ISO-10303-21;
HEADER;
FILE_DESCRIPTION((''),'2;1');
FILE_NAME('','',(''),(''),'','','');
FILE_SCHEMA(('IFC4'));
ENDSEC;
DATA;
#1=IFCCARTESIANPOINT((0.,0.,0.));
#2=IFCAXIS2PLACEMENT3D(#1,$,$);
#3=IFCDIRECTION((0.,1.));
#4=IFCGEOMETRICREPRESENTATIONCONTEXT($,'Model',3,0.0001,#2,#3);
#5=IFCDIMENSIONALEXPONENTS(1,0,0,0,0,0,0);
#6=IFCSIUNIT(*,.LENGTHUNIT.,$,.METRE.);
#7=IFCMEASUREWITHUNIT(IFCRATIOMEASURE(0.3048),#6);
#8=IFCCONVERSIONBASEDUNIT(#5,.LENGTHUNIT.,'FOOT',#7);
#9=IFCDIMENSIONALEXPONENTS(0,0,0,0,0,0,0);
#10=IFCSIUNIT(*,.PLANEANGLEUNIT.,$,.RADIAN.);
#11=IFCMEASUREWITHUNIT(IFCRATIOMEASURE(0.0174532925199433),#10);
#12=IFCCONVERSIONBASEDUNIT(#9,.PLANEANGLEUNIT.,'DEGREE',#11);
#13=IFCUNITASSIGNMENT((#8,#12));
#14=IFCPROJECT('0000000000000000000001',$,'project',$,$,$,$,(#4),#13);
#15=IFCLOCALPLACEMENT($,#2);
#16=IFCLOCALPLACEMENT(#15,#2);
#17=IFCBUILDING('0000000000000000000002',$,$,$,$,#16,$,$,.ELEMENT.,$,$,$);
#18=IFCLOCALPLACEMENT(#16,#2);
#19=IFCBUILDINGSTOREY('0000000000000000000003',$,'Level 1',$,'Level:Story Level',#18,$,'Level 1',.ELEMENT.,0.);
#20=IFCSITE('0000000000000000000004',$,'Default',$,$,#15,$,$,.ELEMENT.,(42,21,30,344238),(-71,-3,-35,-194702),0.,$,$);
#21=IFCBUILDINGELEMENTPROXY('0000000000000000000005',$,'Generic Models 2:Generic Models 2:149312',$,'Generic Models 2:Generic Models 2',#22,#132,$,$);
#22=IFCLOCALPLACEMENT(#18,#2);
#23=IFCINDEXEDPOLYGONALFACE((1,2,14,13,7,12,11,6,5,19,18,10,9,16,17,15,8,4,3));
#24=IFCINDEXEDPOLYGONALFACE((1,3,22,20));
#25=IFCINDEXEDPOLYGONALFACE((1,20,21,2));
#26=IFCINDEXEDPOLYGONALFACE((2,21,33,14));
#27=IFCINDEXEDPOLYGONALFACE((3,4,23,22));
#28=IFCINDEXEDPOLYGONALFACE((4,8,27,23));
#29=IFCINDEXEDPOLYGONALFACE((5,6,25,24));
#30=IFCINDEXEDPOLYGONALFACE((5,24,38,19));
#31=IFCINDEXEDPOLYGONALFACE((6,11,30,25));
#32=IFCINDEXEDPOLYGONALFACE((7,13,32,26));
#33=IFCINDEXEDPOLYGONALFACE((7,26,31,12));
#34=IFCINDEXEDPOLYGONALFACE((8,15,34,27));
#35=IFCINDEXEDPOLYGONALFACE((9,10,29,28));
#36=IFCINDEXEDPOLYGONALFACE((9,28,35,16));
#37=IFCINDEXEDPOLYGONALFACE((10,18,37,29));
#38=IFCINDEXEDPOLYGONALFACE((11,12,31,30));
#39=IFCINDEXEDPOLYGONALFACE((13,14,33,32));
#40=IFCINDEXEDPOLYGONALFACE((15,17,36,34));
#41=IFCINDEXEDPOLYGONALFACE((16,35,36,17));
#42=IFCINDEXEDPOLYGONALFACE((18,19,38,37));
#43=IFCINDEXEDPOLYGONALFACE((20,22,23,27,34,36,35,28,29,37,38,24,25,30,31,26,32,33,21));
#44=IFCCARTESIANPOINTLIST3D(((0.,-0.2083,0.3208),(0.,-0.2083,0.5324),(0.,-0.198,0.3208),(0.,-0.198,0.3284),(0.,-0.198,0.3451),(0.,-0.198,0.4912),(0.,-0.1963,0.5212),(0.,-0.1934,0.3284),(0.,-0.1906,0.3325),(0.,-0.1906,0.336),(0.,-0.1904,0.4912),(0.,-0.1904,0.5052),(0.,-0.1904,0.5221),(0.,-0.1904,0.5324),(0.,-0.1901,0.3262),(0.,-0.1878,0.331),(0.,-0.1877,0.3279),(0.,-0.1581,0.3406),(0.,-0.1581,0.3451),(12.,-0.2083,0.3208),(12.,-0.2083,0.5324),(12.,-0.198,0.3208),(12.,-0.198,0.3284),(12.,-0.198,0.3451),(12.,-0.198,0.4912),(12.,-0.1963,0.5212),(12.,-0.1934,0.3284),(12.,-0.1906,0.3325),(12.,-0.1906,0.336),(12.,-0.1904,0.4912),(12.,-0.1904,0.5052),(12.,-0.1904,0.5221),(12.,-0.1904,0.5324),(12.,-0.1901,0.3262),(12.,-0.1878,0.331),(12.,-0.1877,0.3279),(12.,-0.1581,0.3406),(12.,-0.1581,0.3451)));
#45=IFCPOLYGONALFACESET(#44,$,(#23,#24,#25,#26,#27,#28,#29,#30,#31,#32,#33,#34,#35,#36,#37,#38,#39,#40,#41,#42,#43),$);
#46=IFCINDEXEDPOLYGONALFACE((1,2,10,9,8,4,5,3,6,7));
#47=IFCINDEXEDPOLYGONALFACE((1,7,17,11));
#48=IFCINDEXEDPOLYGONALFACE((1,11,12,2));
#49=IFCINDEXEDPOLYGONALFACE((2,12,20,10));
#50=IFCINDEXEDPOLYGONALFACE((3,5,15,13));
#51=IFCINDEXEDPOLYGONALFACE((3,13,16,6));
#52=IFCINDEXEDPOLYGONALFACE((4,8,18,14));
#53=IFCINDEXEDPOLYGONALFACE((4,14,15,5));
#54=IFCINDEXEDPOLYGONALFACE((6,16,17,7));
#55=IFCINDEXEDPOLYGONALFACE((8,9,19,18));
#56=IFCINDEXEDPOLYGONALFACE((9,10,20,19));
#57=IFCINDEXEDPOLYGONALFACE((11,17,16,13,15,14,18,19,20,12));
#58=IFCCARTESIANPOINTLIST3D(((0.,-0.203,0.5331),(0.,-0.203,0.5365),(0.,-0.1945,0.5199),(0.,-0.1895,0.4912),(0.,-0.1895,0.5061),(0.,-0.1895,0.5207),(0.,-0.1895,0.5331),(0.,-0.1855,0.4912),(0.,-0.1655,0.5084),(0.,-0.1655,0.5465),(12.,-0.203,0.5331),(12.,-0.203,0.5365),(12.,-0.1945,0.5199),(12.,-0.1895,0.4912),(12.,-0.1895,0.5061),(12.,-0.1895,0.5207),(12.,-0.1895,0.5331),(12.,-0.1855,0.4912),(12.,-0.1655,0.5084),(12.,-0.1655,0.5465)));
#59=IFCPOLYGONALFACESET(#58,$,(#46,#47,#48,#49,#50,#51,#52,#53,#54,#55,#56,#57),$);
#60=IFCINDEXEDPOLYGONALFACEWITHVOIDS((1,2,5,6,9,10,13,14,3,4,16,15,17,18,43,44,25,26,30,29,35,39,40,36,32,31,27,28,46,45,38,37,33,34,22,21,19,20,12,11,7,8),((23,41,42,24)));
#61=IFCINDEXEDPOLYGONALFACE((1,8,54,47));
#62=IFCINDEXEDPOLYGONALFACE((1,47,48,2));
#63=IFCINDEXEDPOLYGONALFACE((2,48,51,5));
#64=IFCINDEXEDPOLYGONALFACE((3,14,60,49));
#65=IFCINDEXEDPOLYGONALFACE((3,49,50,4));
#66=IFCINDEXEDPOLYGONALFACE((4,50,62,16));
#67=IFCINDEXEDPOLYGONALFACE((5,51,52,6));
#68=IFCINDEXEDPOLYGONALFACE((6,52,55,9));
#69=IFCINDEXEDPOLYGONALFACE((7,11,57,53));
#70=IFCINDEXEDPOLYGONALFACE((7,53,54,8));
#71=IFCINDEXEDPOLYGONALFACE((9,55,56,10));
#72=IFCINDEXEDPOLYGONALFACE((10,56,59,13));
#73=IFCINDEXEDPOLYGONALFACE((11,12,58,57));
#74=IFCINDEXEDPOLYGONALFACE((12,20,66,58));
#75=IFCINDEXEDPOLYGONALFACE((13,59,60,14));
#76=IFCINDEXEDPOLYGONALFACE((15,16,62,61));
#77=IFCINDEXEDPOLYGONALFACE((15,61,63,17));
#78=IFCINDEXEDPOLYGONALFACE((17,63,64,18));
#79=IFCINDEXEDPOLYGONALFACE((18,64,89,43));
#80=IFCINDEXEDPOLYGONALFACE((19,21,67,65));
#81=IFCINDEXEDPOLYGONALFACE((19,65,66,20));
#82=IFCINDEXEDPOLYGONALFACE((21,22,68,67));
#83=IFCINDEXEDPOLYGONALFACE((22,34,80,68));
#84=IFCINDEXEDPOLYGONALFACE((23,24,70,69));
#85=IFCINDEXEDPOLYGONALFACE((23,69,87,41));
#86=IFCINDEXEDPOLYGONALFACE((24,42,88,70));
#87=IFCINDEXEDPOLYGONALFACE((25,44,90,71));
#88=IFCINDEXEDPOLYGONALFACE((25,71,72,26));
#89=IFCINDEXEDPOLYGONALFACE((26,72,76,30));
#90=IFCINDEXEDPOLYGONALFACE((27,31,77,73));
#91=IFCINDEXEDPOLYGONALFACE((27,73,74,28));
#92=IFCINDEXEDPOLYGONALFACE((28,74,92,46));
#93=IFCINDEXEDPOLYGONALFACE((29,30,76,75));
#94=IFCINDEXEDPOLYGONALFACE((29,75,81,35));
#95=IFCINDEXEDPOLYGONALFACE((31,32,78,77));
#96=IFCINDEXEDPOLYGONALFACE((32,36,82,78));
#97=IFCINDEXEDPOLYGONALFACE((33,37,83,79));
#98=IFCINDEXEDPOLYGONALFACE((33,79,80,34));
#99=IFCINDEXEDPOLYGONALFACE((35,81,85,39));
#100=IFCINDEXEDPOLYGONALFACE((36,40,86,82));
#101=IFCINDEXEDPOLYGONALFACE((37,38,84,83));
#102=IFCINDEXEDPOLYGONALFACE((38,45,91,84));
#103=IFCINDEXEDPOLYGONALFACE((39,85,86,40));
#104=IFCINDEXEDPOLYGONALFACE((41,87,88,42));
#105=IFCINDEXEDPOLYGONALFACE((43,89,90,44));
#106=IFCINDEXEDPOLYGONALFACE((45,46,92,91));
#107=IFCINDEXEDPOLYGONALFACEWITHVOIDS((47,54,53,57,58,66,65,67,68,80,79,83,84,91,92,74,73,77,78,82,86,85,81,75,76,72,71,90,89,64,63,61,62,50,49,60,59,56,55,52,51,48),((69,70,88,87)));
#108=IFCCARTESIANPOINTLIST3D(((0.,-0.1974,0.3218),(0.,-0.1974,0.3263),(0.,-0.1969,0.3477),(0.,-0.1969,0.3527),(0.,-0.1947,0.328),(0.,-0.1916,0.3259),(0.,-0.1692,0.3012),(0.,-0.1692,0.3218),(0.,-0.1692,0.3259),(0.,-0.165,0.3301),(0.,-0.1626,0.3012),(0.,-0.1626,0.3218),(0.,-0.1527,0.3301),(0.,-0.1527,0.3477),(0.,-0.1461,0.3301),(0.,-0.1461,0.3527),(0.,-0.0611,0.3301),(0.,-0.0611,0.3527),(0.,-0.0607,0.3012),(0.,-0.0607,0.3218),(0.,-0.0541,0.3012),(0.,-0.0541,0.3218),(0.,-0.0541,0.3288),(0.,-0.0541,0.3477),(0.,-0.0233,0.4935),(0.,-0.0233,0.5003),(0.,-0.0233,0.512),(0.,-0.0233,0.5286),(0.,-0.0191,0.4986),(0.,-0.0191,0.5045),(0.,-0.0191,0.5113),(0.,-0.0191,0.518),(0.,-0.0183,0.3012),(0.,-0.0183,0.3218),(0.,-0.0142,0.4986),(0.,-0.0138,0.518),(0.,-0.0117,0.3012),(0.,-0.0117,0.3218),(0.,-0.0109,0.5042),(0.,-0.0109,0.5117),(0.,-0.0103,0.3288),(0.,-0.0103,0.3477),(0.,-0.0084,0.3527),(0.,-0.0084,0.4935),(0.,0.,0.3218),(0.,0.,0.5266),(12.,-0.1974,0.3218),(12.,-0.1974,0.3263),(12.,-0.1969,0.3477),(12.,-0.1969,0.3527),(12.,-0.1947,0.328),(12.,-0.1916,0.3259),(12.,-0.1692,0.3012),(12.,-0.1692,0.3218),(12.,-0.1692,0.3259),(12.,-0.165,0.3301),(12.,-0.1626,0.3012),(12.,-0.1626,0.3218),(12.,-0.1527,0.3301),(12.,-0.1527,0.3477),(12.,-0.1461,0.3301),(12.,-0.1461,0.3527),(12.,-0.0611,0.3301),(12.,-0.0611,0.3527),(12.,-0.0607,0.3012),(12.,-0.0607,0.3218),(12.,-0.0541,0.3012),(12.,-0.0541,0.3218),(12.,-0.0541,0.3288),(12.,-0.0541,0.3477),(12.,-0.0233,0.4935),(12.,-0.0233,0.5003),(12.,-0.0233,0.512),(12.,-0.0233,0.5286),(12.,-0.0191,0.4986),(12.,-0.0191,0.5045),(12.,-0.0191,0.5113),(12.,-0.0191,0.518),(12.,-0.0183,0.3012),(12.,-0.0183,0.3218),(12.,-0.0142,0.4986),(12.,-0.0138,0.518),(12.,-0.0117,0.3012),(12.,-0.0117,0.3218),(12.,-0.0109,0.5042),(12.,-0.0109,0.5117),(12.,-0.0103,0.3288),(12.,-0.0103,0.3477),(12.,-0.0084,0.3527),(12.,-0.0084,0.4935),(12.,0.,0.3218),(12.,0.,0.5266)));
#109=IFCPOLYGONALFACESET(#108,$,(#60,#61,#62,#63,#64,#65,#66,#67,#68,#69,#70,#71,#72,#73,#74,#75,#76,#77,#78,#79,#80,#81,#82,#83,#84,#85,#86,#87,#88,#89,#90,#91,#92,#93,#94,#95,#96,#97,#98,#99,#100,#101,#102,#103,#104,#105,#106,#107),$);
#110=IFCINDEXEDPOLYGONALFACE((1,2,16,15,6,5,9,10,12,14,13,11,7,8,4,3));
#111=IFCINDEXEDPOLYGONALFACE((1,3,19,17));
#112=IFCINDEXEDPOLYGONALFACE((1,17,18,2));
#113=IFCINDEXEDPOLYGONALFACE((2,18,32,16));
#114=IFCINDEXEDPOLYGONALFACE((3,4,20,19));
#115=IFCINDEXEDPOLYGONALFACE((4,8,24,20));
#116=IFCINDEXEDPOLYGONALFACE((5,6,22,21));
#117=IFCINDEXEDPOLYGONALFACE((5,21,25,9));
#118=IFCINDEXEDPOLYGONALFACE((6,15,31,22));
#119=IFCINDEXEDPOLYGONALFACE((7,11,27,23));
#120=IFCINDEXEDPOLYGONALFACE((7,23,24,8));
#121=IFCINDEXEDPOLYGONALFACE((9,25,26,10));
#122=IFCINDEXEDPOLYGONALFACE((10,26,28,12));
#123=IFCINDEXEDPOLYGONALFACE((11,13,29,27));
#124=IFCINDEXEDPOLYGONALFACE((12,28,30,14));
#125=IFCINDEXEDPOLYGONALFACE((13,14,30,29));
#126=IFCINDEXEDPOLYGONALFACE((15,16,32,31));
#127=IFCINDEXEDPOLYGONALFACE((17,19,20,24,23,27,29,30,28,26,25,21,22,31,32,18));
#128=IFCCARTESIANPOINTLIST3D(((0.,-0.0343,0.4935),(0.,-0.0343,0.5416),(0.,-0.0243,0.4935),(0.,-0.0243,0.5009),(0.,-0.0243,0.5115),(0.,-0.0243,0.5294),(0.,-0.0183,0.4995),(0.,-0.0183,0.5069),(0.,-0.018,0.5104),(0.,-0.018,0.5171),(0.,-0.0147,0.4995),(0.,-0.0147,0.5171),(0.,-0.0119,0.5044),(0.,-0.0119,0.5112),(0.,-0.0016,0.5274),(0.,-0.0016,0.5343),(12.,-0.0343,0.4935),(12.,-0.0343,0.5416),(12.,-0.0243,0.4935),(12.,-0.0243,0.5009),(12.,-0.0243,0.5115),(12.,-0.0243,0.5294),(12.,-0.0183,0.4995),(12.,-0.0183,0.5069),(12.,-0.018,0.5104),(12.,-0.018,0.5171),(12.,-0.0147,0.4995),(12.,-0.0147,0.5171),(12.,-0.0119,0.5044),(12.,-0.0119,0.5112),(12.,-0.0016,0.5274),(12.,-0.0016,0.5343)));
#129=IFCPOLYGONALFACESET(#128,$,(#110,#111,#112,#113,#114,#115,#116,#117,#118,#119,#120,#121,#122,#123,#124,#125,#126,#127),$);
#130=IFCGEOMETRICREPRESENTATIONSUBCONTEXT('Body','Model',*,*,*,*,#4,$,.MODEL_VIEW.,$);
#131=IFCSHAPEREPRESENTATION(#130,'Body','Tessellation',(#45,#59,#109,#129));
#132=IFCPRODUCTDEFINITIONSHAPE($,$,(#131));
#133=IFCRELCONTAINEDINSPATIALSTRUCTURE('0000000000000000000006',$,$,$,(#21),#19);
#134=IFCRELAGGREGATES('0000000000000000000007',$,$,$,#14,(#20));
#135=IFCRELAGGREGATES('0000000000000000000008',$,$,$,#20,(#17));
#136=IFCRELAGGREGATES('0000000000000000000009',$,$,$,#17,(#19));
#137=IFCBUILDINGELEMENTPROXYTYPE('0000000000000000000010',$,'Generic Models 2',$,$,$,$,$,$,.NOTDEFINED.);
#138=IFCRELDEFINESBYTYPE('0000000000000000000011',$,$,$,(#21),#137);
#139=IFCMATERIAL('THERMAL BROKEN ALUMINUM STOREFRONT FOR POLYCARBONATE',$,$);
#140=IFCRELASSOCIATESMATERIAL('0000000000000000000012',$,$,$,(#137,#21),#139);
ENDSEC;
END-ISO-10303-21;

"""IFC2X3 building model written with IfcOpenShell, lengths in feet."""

from ifc_helpers import new_model, entity, si_unit, converted_unit, direction, frame, origin, place, context, subcontext, project, spatial, polyline, outline, extrude, source, transform, mapped, material, type_object, type_shapes, element, save


model = new_model("IFC2X3")

# Units and contexts
model_context = context("Model", 3, precision=0.0001, world=origin(), true_north=direction((0.0, 1.0)))
body_context = subcontext(model_context, "Body", "Model", "MODEL_VIEW")
ifc_project = project(units=[converted_unit("LENGTHUNIT", "FOOT", entity("IfcRatioMeasure", 0.3048), si_unit("LENGTHUNIT", "METRE"), dimensions=[1, 0, 0, 0, 0, 0, 0]), converted_unit("PLANEANGLEUNIT", "DEGREE", entity("IfcRatioMeasure", 0.0174532925199433), si_unit("PLANEANGLEUNIT", "RADIAN"), dimensions=[0, 0, 0, 0, 0, 0, 0])], contexts=[model_context])

# Site, building, storey
site_placement = place(None, origin())
site = spatial("IfcSite", under=ifc_project, at=site_placement, Name="Default", CompositionType="ELEMENT", RefLatitude=(42, 21, 30, 344238), RefLongitude=(-71, -3, -35, -194702), RefElevation=0.0)
building_placement = place(site_placement, origin())
building = spatial("IfcBuilding", under=site, at=building_placement, CompositionType="ELEMENT")
storey_placement = place(building_placement, origin())
storey = spatial("IfcBuildingStorey", under=building, at=storey_placement, Name="Level 1", ObjectType="Level:Story Level", LongName="Level 1", CompositionType="ELEMENT", Elevation=0.0)

# Building element proxy
ifc_material = material(Name="THERMAL BROKEN ALUMINUM STOREFRONT FOR POLYCARBONATE")
building_element_proxy_type_1 = type_object("IfcBuildingElementProxyType", Name="Generic Models 2", PredefinedType="NOTDEFINED", material=ifc_material)
shared_shape_1 = source(origin(), body_context, "Body", "SweptSolid", [
    extrude(outline(polyline([(-0.0355, -0.058), (-0.0371, -0.0606), (-0.0358, -0.0632), (-0.0318, -0.063), (-0.0278, -0.0652), (-0.0315, -0.0718), (-0.0224, -0.0768), (0.0802, 0.1083), (0.0645, 0.1169), (0.0595, 0.1079), (0.0642, 0.1042), (0.0513, 0.0931), (0.0445, 0.0809), (0.0512, 0.0772), (-0.0197, -0.0506), (-0.0545, -0.0312), (-0.0567, -0.0352), (-0.0306, -0.055), (-0.0322, -0.058), (-0.0355, -0.058)])), frame((0.0, -0.1907, 0.0977), z_axis=(-1.0, 0.0, 0.0), x_axis=(0.0, -0.874529, 0.484974)), (0.0, 0.0, -1.0), 12.0),
    extrude(outline(polyline([(-0.0178, -0.0155), (-0.0144, -0.0155), (-0.0144, -0.002), (-0.0021, -0.002), (-0.0012, -0.007), (0.0126, -0.002), (0.0275, -0.002), (0.0275, 0.002), (0.0102, 0.022), (-0.0278, 0.022), (-0.0178, -0.0155)])), frame((0.0, -0.1875, 0.2175), z_axis=(1.0, 0.0, 0.0), x_axis=(0.0, 0.0, -1.0)), (0.0, 0.0, 1.0), 12.0),
    extrude(outline(polyline([(-0.107, -0.073), (-0.107, -0.058), (-0.1137, -0.058), (-0.118, -0.0623), (-0.1121, -0.0623), (-0.1121, -0.0672), (-0.1177, -0.0704), (-0.1252, -0.0704), (-0.1315, -0.0675), (-0.1315, -0.0623), (-0.1248, -0.0623), (-0.1255, -0.058), (-0.142, -0.058), (-0.1401, -0.0814), (0.0647, -0.0814), (0.0647, -0.0697), (0.0853, -0.0697), (0.0853, -0.0631), (0.0647, -0.0631), (0.0647, -0.0273), (0.0853, -0.0273), (0.0853, -0.0207), (0.0647, -0.0207), (0.0647, 0.0812), (0.0853, 0.0812), (0.0853, 0.0878), (0.0647, 0.0878), (0.0647, 0.1161), (0.0603, 0.1161), (0.0585, 0.1133), (0.0606, 0.1102), (0.0606, 0.0878), (0.0564, 0.0836), (0.0564, 0.0713), (0.0389, 0.0713), (0.0389, 0.1155), (0.0338, 0.1155), (0.0338, 0.0647), (0.0564, 0.0647), (0.0564, -0.0203), (0.0338, -0.0203), (0.0338, -0.073), (-0.107, -0.073)]), holes=[polyline([(0.0577, -0.0711), (0.0389, -0.0711), (0.0389, -0.0273), (0.0577, -0.0273), (0.0577, -0.0711)])]), frame((0.0, -0.0814, 0.0853), z_axis=(-1.0, 0.0, 0.0), x_axis=(0.0, 0.0, -1.0)), (0.0, 0.0, -1.0), 12.0),
    extrude(outline(polyline([(-0.0292, -0.0159), (0.0189, -0.0159), (0.0189, -0.0059), (0.0115, -0.0059), (0.0055, 0.0001), (0.0129, 0.0001), (0.0129, 0.0037), (0.008, 0.0065), (0.0012, 0.0065), (-0.0047, 0.0038), (-0.0047, 0.0004), (0.002, 0.0004), (0.0009, -0.0059), (-0.017, -0.0059), (-0.015, 0.0168), (-0.0219, 0.0168), (-0.0292, -0.0159)])), frame((0.0, -0.0185, 0.2112), z_axis=(1.0, 0.0, 0.0), x_axis=(0.0, 0.0, -1.0)), (0.0, 0.0, 1.0), 12.0),
])
type_shapes(building_element_proxy_type_1, [shared_shape_1])
proxy_1_placement = place(storey_placement, frame((0.0, 0.0, 0.3012)))
element("IfcBuildingElementProxy", 1, at=proxy_1_placement, inside=storey, type_object=building_element_proxy_type_1, material=ifc_material, Name="Generic Models 2:Generic Models 2:149312", ObjectType="Generic Models 2:Generic Models 2", context=body_context, shape_type="MappedRepresentation", body=[
    mapped(shared_shape_1, transform((0.0, 0.0, 0.0), scale=1.0)),
])

save(model, "model.ifc")
